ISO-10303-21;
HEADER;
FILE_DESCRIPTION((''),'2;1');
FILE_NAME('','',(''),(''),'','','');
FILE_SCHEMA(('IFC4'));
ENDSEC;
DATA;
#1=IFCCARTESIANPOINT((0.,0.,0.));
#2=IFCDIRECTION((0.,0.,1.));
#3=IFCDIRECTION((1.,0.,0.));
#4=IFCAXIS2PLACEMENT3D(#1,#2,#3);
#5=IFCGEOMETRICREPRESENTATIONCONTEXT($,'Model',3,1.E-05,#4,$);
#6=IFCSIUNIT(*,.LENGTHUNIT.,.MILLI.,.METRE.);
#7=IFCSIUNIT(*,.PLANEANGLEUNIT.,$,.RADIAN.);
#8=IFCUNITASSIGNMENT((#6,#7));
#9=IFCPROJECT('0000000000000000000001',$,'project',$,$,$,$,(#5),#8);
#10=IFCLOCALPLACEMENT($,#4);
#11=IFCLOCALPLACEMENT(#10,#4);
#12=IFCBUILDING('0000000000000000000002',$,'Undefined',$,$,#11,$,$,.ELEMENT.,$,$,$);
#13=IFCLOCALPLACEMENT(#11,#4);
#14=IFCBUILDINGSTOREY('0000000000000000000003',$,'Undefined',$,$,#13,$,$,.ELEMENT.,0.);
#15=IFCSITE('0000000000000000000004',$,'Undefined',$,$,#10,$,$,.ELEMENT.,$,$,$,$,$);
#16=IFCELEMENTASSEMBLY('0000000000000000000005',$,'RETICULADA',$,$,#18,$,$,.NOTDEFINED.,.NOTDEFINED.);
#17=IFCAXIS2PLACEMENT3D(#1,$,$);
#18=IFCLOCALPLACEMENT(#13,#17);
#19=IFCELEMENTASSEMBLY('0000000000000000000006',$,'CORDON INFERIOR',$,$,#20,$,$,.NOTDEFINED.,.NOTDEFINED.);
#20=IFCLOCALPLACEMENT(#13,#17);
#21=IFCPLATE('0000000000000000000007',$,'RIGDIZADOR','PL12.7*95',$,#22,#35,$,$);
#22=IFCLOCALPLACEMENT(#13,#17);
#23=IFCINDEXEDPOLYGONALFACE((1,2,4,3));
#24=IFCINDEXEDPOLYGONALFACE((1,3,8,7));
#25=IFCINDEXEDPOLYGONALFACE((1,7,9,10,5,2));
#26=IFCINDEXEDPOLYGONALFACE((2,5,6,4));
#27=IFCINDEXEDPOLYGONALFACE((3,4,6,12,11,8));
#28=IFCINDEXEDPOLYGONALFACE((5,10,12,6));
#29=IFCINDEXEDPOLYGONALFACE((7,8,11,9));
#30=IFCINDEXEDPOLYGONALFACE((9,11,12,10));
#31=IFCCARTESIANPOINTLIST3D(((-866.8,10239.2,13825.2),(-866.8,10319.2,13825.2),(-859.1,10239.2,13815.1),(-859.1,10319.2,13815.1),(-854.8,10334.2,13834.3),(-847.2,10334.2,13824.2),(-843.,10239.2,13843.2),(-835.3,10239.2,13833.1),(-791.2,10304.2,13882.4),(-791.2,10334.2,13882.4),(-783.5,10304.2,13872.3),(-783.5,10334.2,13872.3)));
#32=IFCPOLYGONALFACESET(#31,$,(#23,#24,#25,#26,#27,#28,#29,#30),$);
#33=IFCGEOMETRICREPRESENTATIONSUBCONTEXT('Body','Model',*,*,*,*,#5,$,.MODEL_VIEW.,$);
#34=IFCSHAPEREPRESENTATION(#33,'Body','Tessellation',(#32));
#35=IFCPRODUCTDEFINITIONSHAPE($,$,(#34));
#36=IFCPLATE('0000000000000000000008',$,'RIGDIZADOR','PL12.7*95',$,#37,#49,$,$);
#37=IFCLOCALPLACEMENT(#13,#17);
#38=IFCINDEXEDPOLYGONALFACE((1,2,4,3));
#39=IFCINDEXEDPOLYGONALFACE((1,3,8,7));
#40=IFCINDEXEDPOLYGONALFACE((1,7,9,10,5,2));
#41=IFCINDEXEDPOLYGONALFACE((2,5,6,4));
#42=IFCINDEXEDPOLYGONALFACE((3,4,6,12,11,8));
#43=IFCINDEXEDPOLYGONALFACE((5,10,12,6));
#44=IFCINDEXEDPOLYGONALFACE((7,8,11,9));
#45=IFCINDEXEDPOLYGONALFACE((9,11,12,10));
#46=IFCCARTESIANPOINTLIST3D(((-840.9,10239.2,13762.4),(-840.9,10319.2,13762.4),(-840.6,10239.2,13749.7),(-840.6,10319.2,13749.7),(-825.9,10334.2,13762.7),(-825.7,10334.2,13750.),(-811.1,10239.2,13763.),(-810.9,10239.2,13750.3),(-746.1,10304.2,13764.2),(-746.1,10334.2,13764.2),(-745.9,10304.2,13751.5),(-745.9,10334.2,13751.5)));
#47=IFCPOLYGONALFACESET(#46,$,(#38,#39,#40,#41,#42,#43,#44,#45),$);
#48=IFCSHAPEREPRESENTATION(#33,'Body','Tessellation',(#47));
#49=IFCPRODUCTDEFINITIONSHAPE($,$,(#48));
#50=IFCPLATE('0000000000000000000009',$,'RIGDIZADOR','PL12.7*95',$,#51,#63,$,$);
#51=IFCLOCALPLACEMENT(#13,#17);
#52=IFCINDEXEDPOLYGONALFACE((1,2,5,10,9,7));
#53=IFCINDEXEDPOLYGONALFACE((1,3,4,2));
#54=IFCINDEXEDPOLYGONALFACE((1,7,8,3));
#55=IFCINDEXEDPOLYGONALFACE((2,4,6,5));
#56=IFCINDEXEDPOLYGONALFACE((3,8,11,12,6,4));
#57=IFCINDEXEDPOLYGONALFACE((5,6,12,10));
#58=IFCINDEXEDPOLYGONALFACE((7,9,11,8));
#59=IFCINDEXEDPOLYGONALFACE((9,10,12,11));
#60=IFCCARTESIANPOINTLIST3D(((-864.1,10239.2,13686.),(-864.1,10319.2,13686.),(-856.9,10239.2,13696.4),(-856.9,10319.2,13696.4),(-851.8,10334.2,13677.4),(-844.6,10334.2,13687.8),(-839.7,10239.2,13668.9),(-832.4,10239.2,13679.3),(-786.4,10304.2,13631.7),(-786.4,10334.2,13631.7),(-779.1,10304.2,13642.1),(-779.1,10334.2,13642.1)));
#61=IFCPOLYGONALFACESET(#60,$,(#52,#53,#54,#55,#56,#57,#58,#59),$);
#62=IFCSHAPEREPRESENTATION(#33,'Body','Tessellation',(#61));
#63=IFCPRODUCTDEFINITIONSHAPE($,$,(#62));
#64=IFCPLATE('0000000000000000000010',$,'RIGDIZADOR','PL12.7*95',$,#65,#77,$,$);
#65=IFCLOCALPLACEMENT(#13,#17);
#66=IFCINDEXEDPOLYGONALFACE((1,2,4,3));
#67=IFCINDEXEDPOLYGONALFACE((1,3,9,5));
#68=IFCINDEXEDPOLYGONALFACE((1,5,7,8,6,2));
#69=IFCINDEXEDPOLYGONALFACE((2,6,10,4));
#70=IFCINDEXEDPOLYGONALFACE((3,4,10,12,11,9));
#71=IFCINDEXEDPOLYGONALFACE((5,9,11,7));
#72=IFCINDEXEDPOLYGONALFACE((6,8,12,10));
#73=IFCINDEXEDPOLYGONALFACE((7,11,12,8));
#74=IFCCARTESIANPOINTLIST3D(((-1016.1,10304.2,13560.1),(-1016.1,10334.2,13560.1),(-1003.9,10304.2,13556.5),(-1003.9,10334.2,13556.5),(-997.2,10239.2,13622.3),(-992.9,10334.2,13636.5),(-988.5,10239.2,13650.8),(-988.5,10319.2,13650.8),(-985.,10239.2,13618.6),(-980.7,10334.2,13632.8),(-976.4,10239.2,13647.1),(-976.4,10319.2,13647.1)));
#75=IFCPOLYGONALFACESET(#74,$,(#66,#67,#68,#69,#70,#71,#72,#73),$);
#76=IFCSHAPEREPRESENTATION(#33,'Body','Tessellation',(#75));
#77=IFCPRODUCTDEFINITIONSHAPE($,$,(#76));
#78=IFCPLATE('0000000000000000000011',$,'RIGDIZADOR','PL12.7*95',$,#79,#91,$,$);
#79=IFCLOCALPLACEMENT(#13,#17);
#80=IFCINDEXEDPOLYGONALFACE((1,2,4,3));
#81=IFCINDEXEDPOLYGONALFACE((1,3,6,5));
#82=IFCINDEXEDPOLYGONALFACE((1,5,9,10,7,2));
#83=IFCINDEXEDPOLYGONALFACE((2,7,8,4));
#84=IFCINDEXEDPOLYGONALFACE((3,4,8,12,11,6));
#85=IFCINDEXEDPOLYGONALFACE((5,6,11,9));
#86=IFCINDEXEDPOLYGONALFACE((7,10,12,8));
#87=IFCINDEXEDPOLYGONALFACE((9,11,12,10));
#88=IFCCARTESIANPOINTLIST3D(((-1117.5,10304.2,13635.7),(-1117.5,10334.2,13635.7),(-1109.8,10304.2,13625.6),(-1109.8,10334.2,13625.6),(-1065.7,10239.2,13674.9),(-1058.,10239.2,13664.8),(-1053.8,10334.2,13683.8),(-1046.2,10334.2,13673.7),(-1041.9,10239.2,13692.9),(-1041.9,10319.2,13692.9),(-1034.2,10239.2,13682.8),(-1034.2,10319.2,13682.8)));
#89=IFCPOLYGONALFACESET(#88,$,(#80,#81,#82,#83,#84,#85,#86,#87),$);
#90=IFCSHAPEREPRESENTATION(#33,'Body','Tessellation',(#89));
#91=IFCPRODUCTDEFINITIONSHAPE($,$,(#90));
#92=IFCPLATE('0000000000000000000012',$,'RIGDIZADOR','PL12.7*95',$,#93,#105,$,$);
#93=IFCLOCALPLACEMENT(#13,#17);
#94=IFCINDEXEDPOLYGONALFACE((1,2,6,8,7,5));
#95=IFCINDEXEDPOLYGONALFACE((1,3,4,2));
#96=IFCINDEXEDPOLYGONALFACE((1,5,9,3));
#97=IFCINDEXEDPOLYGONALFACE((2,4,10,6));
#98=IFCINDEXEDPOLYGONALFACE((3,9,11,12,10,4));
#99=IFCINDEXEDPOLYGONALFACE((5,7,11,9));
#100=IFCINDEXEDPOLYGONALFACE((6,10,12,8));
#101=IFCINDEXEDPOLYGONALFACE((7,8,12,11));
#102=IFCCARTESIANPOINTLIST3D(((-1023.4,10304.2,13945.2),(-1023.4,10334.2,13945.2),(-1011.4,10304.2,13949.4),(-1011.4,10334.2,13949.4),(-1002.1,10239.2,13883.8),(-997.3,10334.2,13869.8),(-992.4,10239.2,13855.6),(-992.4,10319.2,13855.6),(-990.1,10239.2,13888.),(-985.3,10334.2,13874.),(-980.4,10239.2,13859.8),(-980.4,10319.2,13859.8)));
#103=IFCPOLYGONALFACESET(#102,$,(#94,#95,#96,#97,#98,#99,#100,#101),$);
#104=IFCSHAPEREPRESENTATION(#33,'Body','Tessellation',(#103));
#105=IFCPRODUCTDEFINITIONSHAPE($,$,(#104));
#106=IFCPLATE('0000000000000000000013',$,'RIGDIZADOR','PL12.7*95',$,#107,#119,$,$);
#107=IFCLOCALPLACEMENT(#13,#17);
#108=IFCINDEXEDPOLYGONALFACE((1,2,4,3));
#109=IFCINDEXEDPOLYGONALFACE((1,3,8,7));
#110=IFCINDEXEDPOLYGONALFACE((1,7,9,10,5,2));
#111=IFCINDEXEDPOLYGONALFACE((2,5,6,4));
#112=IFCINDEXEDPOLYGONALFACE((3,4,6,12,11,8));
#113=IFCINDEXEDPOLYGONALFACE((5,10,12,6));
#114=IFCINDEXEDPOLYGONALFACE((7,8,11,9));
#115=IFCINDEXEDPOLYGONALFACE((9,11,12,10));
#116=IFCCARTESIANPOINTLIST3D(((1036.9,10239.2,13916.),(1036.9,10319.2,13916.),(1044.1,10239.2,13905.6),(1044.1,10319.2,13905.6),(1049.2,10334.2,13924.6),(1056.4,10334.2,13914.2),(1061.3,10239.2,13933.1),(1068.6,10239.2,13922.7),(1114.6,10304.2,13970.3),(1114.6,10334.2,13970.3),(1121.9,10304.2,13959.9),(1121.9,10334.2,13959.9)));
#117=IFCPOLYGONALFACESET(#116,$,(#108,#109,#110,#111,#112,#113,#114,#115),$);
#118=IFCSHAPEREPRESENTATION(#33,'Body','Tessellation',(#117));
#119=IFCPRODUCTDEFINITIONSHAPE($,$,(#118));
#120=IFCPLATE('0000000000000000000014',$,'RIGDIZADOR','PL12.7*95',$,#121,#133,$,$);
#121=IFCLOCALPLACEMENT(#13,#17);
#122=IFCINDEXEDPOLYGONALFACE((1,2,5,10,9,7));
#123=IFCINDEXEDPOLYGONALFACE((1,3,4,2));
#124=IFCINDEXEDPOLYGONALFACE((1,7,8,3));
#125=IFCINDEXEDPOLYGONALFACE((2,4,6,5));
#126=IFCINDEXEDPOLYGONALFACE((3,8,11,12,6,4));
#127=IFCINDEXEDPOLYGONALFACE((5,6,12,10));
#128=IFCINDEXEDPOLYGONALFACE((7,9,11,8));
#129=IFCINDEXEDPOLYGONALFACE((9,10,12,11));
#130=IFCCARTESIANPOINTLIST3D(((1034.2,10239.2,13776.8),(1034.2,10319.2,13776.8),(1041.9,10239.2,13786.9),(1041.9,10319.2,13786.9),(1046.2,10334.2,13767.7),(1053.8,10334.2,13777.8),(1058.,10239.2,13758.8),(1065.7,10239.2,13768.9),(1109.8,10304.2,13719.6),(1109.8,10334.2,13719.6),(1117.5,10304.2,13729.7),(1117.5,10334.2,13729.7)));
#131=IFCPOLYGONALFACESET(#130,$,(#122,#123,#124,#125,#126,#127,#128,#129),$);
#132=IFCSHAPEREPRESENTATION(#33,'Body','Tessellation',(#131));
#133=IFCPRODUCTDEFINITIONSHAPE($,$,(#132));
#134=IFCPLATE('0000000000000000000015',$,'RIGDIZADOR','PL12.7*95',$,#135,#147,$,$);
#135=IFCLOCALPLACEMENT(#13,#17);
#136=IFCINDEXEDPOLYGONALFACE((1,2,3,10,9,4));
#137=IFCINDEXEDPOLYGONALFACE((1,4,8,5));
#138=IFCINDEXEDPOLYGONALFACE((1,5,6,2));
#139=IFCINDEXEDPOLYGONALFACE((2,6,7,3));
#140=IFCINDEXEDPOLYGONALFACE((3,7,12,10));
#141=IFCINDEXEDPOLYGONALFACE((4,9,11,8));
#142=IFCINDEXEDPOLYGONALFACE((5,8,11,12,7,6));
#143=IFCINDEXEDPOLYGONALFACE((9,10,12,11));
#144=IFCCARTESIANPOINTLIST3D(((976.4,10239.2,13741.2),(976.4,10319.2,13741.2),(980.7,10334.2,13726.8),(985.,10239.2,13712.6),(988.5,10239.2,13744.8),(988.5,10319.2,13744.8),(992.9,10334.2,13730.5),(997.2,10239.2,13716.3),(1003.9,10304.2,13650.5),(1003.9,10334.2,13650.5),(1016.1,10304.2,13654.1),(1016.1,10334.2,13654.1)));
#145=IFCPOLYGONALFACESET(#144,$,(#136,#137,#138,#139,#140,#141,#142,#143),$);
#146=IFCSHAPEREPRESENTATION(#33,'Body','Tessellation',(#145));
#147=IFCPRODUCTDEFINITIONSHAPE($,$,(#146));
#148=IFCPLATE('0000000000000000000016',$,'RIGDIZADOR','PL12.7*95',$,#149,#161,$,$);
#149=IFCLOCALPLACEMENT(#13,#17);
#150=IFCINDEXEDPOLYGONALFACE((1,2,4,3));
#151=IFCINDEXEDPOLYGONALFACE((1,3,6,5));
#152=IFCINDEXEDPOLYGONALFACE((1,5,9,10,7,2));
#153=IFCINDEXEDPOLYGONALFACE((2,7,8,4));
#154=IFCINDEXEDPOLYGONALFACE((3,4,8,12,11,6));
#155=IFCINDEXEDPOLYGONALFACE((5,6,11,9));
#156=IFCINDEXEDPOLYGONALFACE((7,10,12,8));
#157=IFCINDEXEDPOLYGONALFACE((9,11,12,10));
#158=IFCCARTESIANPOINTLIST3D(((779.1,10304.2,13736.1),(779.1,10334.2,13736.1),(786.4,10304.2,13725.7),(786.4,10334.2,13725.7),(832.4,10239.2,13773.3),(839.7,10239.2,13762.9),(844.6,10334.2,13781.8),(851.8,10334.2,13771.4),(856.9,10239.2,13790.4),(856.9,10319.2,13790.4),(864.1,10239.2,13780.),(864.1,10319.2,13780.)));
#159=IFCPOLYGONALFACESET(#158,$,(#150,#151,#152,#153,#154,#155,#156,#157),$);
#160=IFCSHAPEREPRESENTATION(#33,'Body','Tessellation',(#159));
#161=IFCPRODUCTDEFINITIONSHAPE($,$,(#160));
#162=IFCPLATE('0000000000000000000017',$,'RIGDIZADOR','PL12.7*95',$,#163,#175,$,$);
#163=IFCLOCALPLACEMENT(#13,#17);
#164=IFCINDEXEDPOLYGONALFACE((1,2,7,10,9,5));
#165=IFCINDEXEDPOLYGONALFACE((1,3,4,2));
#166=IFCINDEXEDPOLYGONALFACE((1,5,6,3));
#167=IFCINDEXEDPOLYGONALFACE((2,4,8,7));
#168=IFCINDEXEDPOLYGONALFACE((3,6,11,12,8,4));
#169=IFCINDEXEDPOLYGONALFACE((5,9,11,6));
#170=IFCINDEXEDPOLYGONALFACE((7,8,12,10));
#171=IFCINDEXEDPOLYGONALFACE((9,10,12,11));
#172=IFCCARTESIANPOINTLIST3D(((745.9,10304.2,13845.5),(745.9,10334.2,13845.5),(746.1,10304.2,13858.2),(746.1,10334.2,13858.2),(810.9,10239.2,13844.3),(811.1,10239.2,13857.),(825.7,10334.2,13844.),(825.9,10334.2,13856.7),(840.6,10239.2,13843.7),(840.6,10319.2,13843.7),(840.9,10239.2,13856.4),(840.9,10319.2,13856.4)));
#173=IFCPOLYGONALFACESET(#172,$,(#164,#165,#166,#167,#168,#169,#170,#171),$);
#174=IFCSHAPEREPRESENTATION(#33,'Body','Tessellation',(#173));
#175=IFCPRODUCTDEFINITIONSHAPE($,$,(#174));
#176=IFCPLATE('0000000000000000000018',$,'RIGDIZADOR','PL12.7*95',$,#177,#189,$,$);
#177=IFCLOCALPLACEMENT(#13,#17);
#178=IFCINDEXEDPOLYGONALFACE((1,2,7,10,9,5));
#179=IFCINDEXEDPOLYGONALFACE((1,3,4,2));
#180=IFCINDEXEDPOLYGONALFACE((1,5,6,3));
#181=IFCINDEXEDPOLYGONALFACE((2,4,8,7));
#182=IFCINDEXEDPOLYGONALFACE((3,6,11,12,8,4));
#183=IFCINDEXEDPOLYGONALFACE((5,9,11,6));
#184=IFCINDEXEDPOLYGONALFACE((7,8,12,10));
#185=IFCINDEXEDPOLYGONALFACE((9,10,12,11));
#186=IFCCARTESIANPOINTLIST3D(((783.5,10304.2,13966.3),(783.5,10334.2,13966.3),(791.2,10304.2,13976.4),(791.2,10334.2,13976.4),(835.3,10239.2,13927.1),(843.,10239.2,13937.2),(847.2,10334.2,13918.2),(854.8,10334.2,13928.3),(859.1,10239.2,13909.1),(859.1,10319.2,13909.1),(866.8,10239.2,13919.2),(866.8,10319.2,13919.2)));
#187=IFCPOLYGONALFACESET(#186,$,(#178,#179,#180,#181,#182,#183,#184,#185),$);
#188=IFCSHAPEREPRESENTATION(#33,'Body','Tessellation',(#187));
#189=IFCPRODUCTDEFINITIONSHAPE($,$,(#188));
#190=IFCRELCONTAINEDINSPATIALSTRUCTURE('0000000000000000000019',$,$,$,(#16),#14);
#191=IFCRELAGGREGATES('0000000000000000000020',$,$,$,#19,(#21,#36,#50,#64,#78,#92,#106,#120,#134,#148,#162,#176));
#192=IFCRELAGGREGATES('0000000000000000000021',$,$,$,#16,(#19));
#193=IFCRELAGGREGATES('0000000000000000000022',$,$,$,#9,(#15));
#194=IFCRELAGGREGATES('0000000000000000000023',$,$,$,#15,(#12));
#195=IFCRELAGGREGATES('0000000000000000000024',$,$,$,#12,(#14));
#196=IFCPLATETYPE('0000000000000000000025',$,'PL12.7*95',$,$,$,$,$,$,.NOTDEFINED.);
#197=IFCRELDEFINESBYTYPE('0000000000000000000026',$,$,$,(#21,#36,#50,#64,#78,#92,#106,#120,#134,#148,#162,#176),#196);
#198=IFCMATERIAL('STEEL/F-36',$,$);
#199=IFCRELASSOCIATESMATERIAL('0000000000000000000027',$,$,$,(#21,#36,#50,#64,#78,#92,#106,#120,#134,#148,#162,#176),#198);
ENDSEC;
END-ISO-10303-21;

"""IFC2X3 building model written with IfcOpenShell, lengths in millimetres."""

from ifc_helpers import new_model, si_unit, frame, origin_with_axes, place, context, subcontext, project, spatial, polyline, outline, extrude, material, type_object, element, aggregate, save


model = new_model("IFC2X3")

# Units and contexts
model_context = context("Model", 3, precision=1e-05, world=origin_with_axes())
body_context = subcontext(model_context, "Body", "Model", "MODEL_VIEW")
ifc_project = project(units=[si_unit("LENGTHUNIT", "METRE", prefix="MILLI"), si_unit("PLANEANGLEUNIT", "RADIAN")], contexts=[model_context])

# Site, building, storey
site_placement = place(None, origin_with_axes())
site = spatial("IfcSite", under=ifc_project, at=site_placement, Name="Undefined", CompositionType="ELEMENT")
building_placement = place(site_placement, origin_with_axes())
building = spatial("IfcBuilding", under=site, at=building_placement, Name="Undefined", CompositionType="ELEMENT")
storey_placement = place(building_placement, origin_with_axes())
storey = spatial("IfcBuildingStorey", under=building, at=storey_placement, Name="Undefined", CompositionType="ELEMENT", Elevation=0.0)

# Element assemblies
assembly_1_placement = place(storey_placement, origin_with_axes())
assembly_1 = element("IfcElementAssembly", 1, at=assembly_1_placement, inside=storey, Name="RETICULADA", AssemblyPlace="NOTDEFINED", PredefinedType="NOTDEFINED")
assembly_2_placement = place(assembly_1_placement, origin_with_axes())
assembly_2 = element("IfcElementAssembly", 2, at=assembly_2_placement, Name="CORDON INFERIOR", AssemblyPlace="NOTDEFINED", PredefinedType="NOTDEFINED")
ifc_material_1 = material(Name="STEEL/F-36")

# Plates
plate_type_1 = type_object("IfcPlateType", Name="PL12.7*95", PredefinedType="NOTDEFINED")
plate_1_placement = place(assembly_2_placement, frame((-787.3, 10334.2, 13877.3), z_axis=(-0.603013, 0.0, 0.797731), x_axis=(-0.797731, 0.0, -0.603013)))
plate_1 = element("IfcPlate", 3, at=plate_1_placement, type_object=plate_type_1, material=ifc_material_1, Name="RIGDIZADOR", Description="PL12.7*95", context=body_context, shape_type="SweptSolid", body=[
    extrude(outline(polyline([(0.0, 0.0), (79.8, 0.0), (94.8, 15.0), (94.8, 95.0), (65.0, 95.0), (0.0, 30.0), (0.0, 0.0)])), frame((0.0, 0.0, -6.3), z_axis=(0.0, 0.0, 1.0), x_axis=(1.0, 0.0, 0.0)), (0.0, 0.0, 1.0), 12.7),
])
plate_2_placement = place(assembly_2_placement, frame((-746.0, 10334.2, 13757.9), z_axis=(-0.018953, 0.0, 0.99982), x_axis=(-0.99982, 0.0, -0.018953)))
plate_2 = element("IfcPlate", 4, at=plate_2_placement, type_object=plate_type_1, material=ifc_material_1, Name="RIGDIZADOR", Description="PL12.7*95", context=body_context, shape_type="SweptSolid", body=[
    extrude(outline(polyline([(0.0, 0.0), (79.8, 0.0), (94.8, 15.0), (94.8, 95.0), (65.0, 95.0), (0.0, 30.0), (0.0, 0.0)])), frame((0.0, 0.0, -6.3), z_axis=(0.0, 0.0, 1.0), x_axis=(1.0, 0.0, 0.0)), (0.0, 0.0, 1.0), 12.7),
])
plate_3_placement = place(assembly_2_placement, frame((-782.8, 10334.2, 13636.9), z_axis=(0.572346, 0.0, 0.820012), x_axis=(-0.820012, 0.0, 0.572346)))
plate_3 = element("IfcPlate", 5, at=plate_3_placement, type_object=plate_type_1, material=ifc_material_1, Name="RIGDIZADOR", Description="PL12.7*95", context=body_context, shape_type="SweptSolid", body=[
    extrude(outline(polyline([(0.0, 0.0), (79.8, 0.0), (94.8, 15.0), (94.8, 95.0), (65.0, 95.0), (0.0, 30.0), (0.0, 0.0)])), frame((0.0, 0.0, -6.3), z_axis=(0.0, 0.0, 1.0), x_axis=(1.0, 0.0, 0.0)), (0.0, 0.0, 1.0), 12.7),
])
plate_4_placement = place(assembly_2_placement, frame((-1010.0, 10334.2, 13558.3), z_axis=(0.956742, 0.0, -0.290936), x_axis=(0.290936, 0.0, 0.956742)))
plate_4 = element("IfcPlate", 6, at=plate_4_placement, type_object=plate_type_1, material=ifc_material_1, Name="RIGDIZADOR", Description="PL12.7*95", context=body_context, shape_type="SweptSolid", body=[
    extrude(outline(polyline([(0.0, 0.0), (79.8, 0.0), (94.8, 15.0), (94.8, 95.0), (65.0, 95.0), (0.0, 30.0), (0.0, 0.0)])), frame((0.0, 0.0, -6.3), z_axis=(0.0, 0.0, 1.0), x_axis=(1.0, 0.0, 0.0)), (0.0, 0.0, 1.0), 12.7),
])
plate_5_placement = place(assembly_2_placement, frame((-1113.7, 10334.2, 13630.7), z_axis=(0.603013, 0.0, -0.797731), x_axis=(0.797731, 0.0, 0.603013)))
plate_5 = element("IfcPlate", 7, at=plate_5_placement, type_object=plate_type_1, material=ifc_material_1, Name="RIGDIZADOR", Description="PL12.7*95", context=body_context, shape_type="SweptSolid", body=[
    extrude(outline(polyline([(0.0, 0.0), (79.8, 0.0), (94.8, 15.0), (94.8, 95.0), (65.0, 95.0), (0.0, 30.0), (0.0, 0.0)])), frame((0.0, 0.0, -6.3), z_axis=(0.0, 0.0, 1.0), x_axis=(1.0, 0.0, 0.0)), (0.0, 0.0, 1.0), 12.7),
])
plate_6_placement = place(assembly_2_placement, frame((-1017.4, 10334.2, 13947.3), z_axis=(-0.945029, 0.0, -0.326987), x_axis=(0.326987, 0.0, -0.945029)))
plate_6 = element("IfcPlate", 8, at=plate_6_placement, type_object=plate_type_1, material=ifc_material_1, Name="RIGDIZADOR", Description="PL12.7*95", context=body_context, shape_type="SweptSolid", body=[
    extrude(outline(polyline([(0.0, 0.0), (79.8, 0.0), (94.8, 15.0), (94.8, 95.0), (65.0, 95.0), (0.0, 30.0), (0.0, 0.0)])), frame((0.0, 0.0, -6.3), z_axis=(0.0, 0.0, 1.0), x_axis=(1.0, 0.0, 0.0)), (0.0, 0.0, 1.0), 12.7),
])
plate_7_placement = place(assembly_2_placement, frame((1118.2, 10334.2, 13965.1), z_axis=(-0.572346, 0.0, 0.820012), x_axis=(-0.820012, 0.0, -0.572346)))
plate_7 = element("IfcPlate", 9, at=plate_7_placement, type_object=plate_type_1, material=ifc_material_1, Name="RIGDIZADOR", Description="PL12.7*95", context=body_context, shape_type="SweptSolid", body=[
    extrude(outline(polyline([(0.0, 0.0), (79.8, 0.0), (94.8, 15.0), (94.8, 95.0), (65.0, 95.0), (0.0, 30.0), (0.0, 0.0)])), frame((0.0, 0.0, -6.3), z_axis=(0.0, 0.0, 1.0), x_axis=(1.0, 0.0, 0.0)), (0.0, 0.0, 1.0), 12.7),
])
plate_8_placement = place(assembly_2_placement, frame((1113.7, 10334.2, 13724.7), z_axis=(0.603013, 0.0, 0.797731), x_axis=(-0.797731, 0.0, 0.603013)))
plate_8 = element("IfcPlate", 10, at=plate_8_placement, type_object=plate_type_1, material=ifc_material_1, Name="RIGDIZADOR", Description="PL12.7*95", context=body_context, shape_type="SweptSolid", body=[
    extrude(outline(polyline([(0.0, 0.0), (79.8, 0.0), (94.8, 15.0), (94.8, 95.0), (65.0, 95.0), (0.0, 30.0), (0.0, 0.0)])), frame((0.0, 0.0, -6.3), z_axis=(0.0, 0.0, 1.0), x_axis=(1.0, 0.0, 0.0)), (0.0, 0.0, 1.0), 12.7),
])
plate_9_placement = place(assembly_2_placement, frame((1010.0, 10334.2, 13652.3), z_axis=(0.956742, 0.0, 0.290936), x_axis=(-0.290936, 0.0, 0.956742)))
plate_9 = element("IfcPlate", 11, at=plate_9_placement, type_object=plate_type_1, material=ifc_material_1, Name="RIGDIZADOR", Description="PL12.7*95", context=body_context, shape_type="SweptSolid", body=[
    extrude(outline(polyline([(0.0, 0.0), (79.8, 0.0), (94.8, 15.0), (94.8, 95.0), (65.0, 95.0), (0.0, 30.0), (0.0, 0.0)])), frame((0.0, 0.0, -6.3), z_axis=(0.0, 0.0, 1.0), x_axis=(1.0, 0.0, 0.0)), (0.0, 0.0, 1.0), 12.7),
])
plate_10_placement = place(assembly_2_placement, frame((782.8, 10334.2, 13730.9), z_axis=(0.572346, 0.0, -0.820012), x_axis=(0.820012, 0.0, 0.572346)))
plate_10 = element("IfcPlate", 12, at=plate_10_placement, type_object=plate_type_1, material=ifc_material_1, Name="RIGDIZADOR", Description="PL12.7*95", context=body_context, shape_type="SweptSolid", body=[
    extrude(outline(polyline([(0.0, 0.0), (79.8, 0.0), (94.8, 15.0), (94.8, 95.0), (65.0, 95.0), (0.0, 30.0), (0.0, 0.0)])), frame((0.0, 0.0, -6.3), z_axis=(0.0, 0.0, 1.0), x_axis=(1.0, 0.0, 0.0)), (0.0, 0.0, 1.0), 12.7),
])
plate_11_placement = place(assembly_2_placement, frame((746.0, 10334.2, 13851.9), z_axis=(-0.018953, 0.0, -0.99982), x_axis=(0.99982, 0.0, -0.018953)))
plate_11 = element("IfcPlate", 13, at=plate_11_placement, type_object=plate_type_1, material=ifc_material_1, Name="RIGDIZADOR", Description="PL12.7*95", context=body_context, shape_type="SweptSolid", body=[
    extrude(outline(polyline([(0.0, 0.0), (79.8, 0.0), (94.8, 15.0), (94.8, 95.0), (65.0, 95.0), (0.0, 30.0), (0.0, 0.0)])), frame((0.0, 0.0, -6.3), z_axis=(0.0, 0.0, 1.0), x_axis=(1.0, 0.0, 0.0)), (0.0, 0.0, 1.0), 12.7),
])
plate_12_placement = place(assembly_2_placement, frame((787.3, 10334.2, 13971.3), z_axis=(-0.603013, 0.0, -0.797731), x_axis=(0.797731, 0.0, -0.603013)))
plate_12 = element("IfcPlate", 14, at=plate_12_placement, type_object=plate_type_1, material=ifc_material_1, Name="RIGDIZADOR", Description="PL12.7*95", context=body_context, shape_type="SweptSolid", body=[
    extrude(outline(polyline([(0.0, 0.0), (79.8, 0.0), (94.8, 15.0), (94.8, 95.0), (65.0, 95.0), (0.0, 30.0), (0.0, 0.0)])), frame((0.0, 0.0, -6.3), z_axis=(0.0, 0.0, 1.0), x_axis=(1.0, 0.0, 0.0)), (0.0, 0.0, 1.0), 12.7),
])
aggregate(assembly_2, [plate_1, plate_2, plate_3, plate_4, plate_5, plate_6, plate_7, plate_8, plate_9, plate_10, plate_11, plate_12])

aggregate(assembly_1, [assembly_2])

save(model, "model.ifc")
